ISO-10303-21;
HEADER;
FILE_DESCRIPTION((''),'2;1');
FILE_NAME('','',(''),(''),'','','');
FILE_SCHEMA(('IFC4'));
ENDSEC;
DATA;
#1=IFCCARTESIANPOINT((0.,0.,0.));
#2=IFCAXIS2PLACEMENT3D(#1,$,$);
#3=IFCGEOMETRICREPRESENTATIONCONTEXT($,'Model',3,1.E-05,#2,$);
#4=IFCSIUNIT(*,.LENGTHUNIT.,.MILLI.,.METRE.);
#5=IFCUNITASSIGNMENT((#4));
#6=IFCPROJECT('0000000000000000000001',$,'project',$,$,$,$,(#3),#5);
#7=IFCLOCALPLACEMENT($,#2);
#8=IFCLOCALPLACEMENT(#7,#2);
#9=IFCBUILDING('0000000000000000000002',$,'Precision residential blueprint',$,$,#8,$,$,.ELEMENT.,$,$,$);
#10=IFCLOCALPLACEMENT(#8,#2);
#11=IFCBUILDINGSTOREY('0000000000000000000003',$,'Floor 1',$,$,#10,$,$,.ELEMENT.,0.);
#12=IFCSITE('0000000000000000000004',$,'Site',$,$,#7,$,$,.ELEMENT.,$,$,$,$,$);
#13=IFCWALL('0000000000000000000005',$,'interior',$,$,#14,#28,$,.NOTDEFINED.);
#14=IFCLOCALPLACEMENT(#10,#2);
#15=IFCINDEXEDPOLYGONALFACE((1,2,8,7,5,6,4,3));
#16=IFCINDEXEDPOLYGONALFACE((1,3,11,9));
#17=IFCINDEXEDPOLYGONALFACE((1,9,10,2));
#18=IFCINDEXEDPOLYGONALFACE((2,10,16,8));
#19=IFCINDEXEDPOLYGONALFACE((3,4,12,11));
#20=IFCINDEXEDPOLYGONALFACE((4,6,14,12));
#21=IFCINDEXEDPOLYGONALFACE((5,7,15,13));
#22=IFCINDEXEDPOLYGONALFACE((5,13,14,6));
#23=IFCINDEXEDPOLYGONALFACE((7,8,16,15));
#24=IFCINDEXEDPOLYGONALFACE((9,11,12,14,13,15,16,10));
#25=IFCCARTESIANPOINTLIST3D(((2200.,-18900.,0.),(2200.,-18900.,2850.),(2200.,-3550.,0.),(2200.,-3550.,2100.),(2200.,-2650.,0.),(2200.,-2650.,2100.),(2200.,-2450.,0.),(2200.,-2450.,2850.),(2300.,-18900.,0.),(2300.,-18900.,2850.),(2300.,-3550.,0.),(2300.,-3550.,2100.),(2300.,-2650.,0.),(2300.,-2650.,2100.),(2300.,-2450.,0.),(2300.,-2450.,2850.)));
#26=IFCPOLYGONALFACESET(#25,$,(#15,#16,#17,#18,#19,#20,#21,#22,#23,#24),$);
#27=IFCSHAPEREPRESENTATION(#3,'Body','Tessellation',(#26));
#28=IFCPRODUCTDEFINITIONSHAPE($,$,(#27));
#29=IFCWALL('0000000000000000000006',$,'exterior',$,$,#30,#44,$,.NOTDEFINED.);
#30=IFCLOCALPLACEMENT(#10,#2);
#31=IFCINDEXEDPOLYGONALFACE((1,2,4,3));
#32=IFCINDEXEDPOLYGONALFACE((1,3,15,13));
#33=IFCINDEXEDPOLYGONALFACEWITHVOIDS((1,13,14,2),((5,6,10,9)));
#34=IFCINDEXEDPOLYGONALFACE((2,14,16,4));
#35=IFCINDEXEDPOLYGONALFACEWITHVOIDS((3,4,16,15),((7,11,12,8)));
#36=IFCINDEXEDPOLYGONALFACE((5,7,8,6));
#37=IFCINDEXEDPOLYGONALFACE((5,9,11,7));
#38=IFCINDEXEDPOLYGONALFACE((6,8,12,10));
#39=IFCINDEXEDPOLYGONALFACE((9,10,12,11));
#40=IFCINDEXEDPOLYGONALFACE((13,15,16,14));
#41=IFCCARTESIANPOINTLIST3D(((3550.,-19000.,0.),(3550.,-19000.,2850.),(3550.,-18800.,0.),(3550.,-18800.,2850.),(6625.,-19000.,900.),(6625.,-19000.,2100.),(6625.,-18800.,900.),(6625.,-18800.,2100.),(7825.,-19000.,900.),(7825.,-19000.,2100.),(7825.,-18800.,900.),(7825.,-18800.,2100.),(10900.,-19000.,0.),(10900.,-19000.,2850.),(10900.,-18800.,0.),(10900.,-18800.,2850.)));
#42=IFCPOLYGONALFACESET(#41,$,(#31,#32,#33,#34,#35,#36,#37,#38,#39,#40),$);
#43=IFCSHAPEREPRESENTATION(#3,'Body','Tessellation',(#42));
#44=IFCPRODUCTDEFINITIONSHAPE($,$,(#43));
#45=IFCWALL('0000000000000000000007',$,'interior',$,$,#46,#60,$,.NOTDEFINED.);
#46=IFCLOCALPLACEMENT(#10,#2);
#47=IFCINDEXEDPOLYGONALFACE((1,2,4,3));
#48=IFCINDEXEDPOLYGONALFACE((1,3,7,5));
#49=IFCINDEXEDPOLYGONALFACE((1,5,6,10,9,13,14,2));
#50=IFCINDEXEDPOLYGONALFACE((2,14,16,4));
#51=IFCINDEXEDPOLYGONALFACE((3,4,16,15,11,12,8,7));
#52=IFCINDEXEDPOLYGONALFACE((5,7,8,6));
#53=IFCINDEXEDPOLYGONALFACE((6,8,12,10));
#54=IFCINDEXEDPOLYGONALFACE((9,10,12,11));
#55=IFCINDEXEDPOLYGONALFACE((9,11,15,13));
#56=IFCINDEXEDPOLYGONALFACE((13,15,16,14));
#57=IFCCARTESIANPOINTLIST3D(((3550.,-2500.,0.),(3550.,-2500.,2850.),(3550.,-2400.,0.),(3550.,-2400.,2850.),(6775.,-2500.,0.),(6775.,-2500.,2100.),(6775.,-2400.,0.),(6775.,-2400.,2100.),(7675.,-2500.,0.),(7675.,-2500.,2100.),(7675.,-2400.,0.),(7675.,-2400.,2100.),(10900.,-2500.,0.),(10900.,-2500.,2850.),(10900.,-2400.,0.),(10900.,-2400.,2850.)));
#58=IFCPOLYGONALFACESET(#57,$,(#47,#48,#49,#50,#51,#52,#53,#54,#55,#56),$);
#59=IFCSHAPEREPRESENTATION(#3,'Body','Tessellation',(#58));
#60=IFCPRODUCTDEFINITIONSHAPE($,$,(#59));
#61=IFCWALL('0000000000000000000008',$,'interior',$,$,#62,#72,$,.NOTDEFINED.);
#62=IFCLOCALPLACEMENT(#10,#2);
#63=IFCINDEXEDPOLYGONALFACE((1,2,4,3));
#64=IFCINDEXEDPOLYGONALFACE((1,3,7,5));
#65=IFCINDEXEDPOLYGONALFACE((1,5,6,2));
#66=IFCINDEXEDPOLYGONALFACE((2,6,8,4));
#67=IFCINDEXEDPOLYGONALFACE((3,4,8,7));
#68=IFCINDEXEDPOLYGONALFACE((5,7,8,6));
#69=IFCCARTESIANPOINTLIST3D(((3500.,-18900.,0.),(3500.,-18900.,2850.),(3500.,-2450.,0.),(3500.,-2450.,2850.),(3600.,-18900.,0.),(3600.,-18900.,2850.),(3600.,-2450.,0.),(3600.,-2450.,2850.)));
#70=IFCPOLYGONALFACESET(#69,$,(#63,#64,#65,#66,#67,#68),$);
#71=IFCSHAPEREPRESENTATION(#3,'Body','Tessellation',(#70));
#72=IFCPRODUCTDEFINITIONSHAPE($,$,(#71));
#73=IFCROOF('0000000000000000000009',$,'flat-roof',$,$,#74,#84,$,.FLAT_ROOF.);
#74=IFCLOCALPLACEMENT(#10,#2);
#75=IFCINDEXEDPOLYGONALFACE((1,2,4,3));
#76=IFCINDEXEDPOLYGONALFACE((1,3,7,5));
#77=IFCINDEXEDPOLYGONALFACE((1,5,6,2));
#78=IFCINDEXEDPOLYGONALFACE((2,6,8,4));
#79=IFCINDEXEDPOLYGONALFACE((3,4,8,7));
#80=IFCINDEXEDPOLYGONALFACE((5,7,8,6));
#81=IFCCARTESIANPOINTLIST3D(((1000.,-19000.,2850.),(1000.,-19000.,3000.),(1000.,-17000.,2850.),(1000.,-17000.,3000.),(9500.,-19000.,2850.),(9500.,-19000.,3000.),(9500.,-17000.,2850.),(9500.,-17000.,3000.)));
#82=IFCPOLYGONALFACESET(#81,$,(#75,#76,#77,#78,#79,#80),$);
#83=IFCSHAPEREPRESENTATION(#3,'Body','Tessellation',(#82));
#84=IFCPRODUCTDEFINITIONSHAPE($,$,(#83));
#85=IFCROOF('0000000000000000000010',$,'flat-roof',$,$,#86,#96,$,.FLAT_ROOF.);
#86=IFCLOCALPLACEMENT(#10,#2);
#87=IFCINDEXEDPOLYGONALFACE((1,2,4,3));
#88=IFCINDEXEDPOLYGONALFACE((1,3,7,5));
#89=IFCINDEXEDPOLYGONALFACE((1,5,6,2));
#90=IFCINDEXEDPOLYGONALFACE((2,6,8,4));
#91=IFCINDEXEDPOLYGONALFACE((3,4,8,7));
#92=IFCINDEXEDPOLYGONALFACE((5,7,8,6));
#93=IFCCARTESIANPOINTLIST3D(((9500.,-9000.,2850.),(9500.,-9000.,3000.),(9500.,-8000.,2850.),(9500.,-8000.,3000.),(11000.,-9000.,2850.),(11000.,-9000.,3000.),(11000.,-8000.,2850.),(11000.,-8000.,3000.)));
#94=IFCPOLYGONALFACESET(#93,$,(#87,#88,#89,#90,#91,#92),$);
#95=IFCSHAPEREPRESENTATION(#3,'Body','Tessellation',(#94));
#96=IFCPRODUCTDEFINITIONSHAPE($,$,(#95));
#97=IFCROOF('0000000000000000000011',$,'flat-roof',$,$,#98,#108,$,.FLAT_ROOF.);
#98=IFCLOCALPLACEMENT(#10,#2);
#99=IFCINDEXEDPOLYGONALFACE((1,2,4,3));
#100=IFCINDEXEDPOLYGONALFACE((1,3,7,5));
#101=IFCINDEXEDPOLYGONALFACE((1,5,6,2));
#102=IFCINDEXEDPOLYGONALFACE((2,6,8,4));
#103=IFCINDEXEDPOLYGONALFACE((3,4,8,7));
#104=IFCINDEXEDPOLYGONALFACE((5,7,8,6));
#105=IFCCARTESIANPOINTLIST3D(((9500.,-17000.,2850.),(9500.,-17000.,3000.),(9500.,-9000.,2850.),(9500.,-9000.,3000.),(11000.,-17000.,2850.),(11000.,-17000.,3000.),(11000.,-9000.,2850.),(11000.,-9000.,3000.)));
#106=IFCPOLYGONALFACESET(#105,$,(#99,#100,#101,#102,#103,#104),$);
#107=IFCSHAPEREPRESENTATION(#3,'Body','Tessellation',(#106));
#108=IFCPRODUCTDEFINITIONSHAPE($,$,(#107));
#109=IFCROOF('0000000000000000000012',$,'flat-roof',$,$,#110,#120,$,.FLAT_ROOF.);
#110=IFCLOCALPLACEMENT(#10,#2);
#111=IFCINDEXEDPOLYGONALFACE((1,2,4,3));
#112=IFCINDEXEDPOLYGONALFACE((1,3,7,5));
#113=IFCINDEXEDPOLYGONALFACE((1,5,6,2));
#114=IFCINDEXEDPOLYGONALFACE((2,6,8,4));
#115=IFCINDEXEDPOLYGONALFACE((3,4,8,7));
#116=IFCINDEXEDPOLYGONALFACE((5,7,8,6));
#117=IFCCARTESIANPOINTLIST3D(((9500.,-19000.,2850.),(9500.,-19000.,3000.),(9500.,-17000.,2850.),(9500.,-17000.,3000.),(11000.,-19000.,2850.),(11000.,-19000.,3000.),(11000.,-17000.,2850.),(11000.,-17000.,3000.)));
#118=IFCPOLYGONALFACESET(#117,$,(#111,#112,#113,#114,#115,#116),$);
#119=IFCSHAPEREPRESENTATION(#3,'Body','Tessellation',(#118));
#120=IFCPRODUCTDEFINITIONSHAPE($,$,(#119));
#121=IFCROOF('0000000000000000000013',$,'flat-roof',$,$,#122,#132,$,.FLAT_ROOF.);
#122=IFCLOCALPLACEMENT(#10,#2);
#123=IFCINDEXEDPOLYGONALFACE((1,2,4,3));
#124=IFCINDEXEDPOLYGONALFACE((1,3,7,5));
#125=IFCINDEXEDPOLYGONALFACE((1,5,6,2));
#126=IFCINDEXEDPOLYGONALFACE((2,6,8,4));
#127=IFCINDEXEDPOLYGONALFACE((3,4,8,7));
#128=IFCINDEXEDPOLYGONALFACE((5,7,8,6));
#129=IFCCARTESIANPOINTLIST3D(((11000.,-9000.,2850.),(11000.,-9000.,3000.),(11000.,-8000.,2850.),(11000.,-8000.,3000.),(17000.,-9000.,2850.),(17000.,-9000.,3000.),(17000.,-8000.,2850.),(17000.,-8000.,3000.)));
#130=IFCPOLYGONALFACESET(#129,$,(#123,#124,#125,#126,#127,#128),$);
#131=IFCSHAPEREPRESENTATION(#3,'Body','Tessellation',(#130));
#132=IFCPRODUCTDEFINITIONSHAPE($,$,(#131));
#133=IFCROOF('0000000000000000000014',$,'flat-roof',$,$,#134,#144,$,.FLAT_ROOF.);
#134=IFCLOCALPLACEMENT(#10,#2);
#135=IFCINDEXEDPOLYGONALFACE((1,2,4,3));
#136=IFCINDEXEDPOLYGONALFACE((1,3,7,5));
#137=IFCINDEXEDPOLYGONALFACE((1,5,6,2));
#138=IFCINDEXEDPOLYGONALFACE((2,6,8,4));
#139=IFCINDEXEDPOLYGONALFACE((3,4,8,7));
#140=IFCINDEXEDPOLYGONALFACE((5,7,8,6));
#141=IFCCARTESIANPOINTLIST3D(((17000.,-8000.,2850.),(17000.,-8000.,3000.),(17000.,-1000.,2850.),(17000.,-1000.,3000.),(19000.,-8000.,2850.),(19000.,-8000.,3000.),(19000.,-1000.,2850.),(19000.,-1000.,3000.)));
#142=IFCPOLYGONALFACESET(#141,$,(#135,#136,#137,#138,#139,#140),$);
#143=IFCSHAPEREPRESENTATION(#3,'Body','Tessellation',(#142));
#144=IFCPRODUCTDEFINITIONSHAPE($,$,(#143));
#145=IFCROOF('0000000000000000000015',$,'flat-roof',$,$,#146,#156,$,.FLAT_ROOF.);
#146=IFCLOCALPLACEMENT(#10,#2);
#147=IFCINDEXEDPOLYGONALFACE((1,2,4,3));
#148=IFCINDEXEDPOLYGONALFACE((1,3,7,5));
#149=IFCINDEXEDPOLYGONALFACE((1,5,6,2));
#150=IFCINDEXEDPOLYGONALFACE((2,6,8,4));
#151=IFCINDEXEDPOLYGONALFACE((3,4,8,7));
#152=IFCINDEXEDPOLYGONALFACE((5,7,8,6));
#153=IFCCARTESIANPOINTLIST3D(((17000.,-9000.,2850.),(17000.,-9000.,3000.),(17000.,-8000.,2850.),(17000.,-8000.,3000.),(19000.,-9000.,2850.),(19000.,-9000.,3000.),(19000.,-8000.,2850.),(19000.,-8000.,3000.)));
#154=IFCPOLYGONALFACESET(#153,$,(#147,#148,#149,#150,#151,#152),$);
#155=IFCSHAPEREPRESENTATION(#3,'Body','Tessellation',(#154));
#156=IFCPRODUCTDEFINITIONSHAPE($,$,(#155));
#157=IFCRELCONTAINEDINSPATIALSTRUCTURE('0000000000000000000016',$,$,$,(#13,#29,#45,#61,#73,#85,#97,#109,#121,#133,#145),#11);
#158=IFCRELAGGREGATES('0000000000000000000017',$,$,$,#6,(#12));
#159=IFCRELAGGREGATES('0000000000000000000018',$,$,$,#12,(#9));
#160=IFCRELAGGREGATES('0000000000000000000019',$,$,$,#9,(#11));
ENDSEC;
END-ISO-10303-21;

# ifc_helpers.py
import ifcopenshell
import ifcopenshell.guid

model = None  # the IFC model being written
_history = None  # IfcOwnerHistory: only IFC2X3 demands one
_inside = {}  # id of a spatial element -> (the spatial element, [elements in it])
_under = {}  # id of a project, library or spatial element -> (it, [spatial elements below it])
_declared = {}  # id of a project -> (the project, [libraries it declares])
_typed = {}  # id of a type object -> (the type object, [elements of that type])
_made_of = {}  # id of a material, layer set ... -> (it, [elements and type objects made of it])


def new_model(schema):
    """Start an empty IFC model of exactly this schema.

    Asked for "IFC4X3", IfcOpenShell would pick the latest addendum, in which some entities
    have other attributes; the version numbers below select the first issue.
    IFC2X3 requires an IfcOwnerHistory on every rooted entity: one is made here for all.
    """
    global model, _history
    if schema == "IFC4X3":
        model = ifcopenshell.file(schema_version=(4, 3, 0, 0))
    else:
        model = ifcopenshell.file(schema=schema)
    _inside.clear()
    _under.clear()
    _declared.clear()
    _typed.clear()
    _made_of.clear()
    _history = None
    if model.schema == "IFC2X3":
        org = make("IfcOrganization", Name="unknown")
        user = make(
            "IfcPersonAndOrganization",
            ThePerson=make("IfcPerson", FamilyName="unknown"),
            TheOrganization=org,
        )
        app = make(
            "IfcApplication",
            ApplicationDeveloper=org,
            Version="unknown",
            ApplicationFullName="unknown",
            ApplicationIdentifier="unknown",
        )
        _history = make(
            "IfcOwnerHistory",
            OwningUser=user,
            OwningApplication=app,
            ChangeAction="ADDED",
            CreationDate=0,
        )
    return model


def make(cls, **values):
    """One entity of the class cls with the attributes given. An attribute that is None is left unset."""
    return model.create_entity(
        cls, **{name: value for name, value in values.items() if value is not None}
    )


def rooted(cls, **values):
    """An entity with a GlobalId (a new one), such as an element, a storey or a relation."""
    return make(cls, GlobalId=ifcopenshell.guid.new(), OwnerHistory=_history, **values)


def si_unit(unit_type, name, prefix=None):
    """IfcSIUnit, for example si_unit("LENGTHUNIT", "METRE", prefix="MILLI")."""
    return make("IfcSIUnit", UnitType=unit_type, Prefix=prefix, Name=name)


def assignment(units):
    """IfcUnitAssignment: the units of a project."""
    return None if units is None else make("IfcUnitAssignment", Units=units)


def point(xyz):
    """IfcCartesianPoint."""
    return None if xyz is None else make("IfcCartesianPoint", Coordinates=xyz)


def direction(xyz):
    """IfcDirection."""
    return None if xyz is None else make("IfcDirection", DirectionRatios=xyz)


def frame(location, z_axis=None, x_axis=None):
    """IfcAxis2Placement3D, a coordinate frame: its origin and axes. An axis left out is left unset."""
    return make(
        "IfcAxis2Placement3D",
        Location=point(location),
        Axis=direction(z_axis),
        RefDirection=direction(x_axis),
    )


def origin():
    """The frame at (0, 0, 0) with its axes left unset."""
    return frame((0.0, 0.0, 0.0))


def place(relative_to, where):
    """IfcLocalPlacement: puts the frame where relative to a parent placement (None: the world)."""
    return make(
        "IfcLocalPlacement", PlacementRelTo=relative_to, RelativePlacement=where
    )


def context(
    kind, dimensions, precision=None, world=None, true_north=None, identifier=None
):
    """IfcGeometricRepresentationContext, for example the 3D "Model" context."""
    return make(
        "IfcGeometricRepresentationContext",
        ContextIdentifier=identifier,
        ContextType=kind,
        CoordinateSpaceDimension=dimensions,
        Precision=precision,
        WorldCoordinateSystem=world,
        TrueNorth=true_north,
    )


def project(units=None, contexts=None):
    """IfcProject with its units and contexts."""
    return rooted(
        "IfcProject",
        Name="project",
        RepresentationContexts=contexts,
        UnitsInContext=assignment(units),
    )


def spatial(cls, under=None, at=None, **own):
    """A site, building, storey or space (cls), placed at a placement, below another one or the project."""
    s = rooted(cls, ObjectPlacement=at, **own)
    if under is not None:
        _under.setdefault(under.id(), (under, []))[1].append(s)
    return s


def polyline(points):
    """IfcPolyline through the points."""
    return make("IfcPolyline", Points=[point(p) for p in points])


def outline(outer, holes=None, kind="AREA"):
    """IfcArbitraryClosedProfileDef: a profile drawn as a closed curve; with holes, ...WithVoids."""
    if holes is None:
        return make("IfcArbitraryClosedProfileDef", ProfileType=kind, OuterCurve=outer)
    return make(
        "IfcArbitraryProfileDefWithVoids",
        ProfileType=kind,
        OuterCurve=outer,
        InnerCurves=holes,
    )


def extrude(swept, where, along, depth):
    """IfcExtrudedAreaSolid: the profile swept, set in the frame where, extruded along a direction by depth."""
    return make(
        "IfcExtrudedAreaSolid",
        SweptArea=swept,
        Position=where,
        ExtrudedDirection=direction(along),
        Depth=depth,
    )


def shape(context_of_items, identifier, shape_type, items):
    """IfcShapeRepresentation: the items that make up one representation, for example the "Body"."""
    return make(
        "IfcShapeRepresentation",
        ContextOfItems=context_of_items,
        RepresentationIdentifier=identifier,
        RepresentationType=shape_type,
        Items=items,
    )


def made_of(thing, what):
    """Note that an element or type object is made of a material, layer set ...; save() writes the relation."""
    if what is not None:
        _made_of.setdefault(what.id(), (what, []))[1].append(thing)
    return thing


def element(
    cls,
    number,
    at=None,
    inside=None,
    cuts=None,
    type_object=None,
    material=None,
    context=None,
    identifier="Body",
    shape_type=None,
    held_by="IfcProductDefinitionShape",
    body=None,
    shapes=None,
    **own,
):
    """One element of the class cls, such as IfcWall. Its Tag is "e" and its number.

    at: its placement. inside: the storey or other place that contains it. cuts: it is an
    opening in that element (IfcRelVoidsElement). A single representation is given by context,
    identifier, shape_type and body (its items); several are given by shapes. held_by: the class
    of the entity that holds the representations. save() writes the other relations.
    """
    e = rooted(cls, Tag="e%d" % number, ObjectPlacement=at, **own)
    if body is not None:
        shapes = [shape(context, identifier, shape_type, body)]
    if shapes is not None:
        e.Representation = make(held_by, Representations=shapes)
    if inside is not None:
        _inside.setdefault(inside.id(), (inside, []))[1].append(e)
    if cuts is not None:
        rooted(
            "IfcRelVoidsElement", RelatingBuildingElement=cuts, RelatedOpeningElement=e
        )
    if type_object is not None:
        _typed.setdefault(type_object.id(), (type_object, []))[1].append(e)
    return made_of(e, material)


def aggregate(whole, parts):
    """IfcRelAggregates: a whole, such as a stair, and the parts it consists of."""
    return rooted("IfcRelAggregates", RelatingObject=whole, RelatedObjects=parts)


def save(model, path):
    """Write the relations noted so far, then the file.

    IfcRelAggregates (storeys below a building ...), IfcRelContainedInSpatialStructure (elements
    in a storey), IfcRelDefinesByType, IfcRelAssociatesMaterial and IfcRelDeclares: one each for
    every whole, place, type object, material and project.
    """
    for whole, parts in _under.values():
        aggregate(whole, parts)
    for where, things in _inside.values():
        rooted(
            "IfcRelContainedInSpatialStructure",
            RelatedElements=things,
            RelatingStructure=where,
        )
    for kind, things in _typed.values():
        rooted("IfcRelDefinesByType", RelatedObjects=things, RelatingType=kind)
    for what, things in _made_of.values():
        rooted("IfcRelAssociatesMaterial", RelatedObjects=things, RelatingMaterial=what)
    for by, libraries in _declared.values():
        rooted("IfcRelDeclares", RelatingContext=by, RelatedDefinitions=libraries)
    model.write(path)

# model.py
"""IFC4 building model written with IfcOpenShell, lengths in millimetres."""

from ifc_helpers import new_model, si_unit, frame, origin, place, context, project, spatial, polyline, outline, extrude, element, save


model = new_model("IFC4")

# Units and contexts
model_context = context("Model", 3, precision=1e-05, world=origin())
ifc_project = project(units=[si_unit("LENGTHUNIT", "METRE", prefix="MILLI")], contexts=[model_context])

# Site, building, storey
site_placement = place(None, origin())
site = spatial("IfcSite", under=ifc_project, at=site_placement, Name="Site", CompositionType="ELEMENT")
building_placement = place(site_placement, origin())
building = spatial("IfcBuilding", under=site, at=building_placement, Name="Precision residential blueprint", CompositionType="ELEMENT")
storey_placement = place(building_placement, origin())
storey = spatial("IfcBuildingStorey", under=building, at=storey_placement, Name="Floor 1", CompositionType="ELEMENT", Elevation=0.0)

# Walls, openings
wall_1_placement = place(storey_placement, origin())
wall_1 = element("IfcWall", 1, at=wall_1_placement, inside=storey, Name="interior", PredefinedType="NOTDEFINED", context=model_context, shape_type="SweptSolid", body=[
    extrude(outline(polyline([(2300.0, -2450.0), (2300.0, -18900.0), (2200.0, -18900.0), (2200.0, -2450.0), (2300.0, -2450.0)])), origin(), (0.0, 0.0, 1.0), 2850.0),
])
opening_1_placement = place(storey_placement, origin())
element("IfcOpeningElement", 2, at=opening_1_placement, cuts=wall_1, PredefinedType="OPENING", context=model_context, shape_type="SweptSolid", body=[
    extrude(outline(polyline([(2300.0, -2650.0), (2300.0, -3550.0), (2200.0, -3550.0), (2200.0, -2650.0), (2300.0, -2650.0)])), origin(), (0.0, 0.0, 1.0), 2100.0),
])
wall_2_placement = place(storey_placement, origin())
wall_2 = element("IfcWall", 3, at=wall_2_placement, inside=storey, Name="exterior", PredefinedType="NOTDEFINED", context=model_context, shape_type="SweptSolid", body=[
    extrude(outline(polyline([(3550.0, -18800.0), (10900.0, -18800.0), (10900.0, -19000.0), (3550.0, -19000.0), (3550.0, -18800.0)])), origin(), (0.0, 0.0, 1.0), 2850.0),
])
opening_2_placement = place(storey_placement, origin())
element("IfcOpeningElement", 4, at=opening_2_placement, cuts=wall_2, PredefinedType="OPENING", context=model_context, shape_type="SweptSolid", body=[
    extrude(outline(polyline([(6625.0, -18800.0), (7825.0, -18800.0), (7825.0, -19000.0), (6625.0, -19000.0), (6625.0, -18800.0)])), frame((0.0, 0.0, 900.0)), (0.0, 0.0, 1.0), 1200.0),
])
wall_3_placement = place(storey_placement, origin())
wall_3 = element("IfcWall", 5, at=wall_3_placement, inside=storey, Name="interior", PredefinedType="NOTDEFINED", context=model_context, shape_type="SweptSolid", body=[
    extrude(outline(polyline([(3550.0, -2400.0), (10900.0, -2400.0), (10900.0, -2500.0), (3550.0, -2500.0), (3550.0, -2400.0)])), origin(), (0.0, 0.0, 1.0), 2850.0),
])
opening_3_placement = place(storey_placement, origin())
element("IfcOpeningElement", 6, at=opening_3_placement, cuts=wall_3, PredefinedType="OPENING", context=model_context, shape_type="SweptSolid", body=[
    extrude(outline(polyline([(6775.0, -2400.0), (7675.0, -2400.0), (7675.0, -2500.0), (6775.0, -2500.0), (6775.0, -2400.0)])), origin(), (0.0, 0.0, 1.0), 2100.0),
])

# Wall
wall_4_placement = place(storey_placement, origin())
element("IfcWall", 7, at=wall_4_placement, inside=storey, Name="interior", PredefinedType="NOTDEFINED", context=model_context, shape_type="SweptSolid", body=[
    extrude(outline(polyline([(3600.0, -2450.0), (3600.0, -18900.0), (3500.0, -18900.0), (3500.0, -2450.0), (3600.0, -2450.0)])), origin(), (0.0, 0.0, 1.0), 2850.0),
])

# Roofs
roof_1_placement = place(storey_placement, origin())
element("IfcRoof", 8, at=roof_1_placement, inside=storey, Name="flat-roof", PredefinedType="FLAT_ROOF", context=model_context, shape_type="SweptSolid", body=[
    extrude(outline(polyline([(1000.0, -19000.0), (9500.0, -19000.0), (9500.0, -17000.0), (1000.0, -17000.0), (1000.0, -19000.0)])), frame((0.0, 0.0, 2850.0)), (0.0, 0.0, 1.0), 150.0),
])
roof_2_placement = place(storey_placement, origin())
element("IfcRoof", 9, at=roof_2_placement, inside=storey, Name="flat-roof", PredefinedType="FLAT_ROOF", context=model_context, shape_type="SweptSolid", body=[
    extrude(outline(polyline([(9500.0, -9000.0), (11000.0, -9000.0), (11000.0, -8000.0), (9500.0, -8000.0), (9500.0, -9000.0)])), frame((0.0, 0.0, 2850.0)), (0.0, 0.0, 1.0), 150.0),
])
roof_3_placement = place(storey_placement, origin())
element("IfcRoof", 10, at=roof_3_placement, inside=storey, Name="flat-roof", PredefinedType="FLAT_ROOF", context=model_context, shape_type="SweptSolid", body=[
    extrude(outline(polyline([(9500.0, -17000.0), (11000.0, -17000.0), (11000.0, -9000.0), (9500.0, -9000.0), (9500.0, -17000.0)])), frame((0.0, 0.0, 2850.0)), (0.0, 0.0, 1.0), 150.0),
])
roof_4_placement = place(storey_placement, origin())
element("IfcRoof", 11, at=roof_4_placement, inside=storey, Name="flat-roof", PredefinedType="FLAT_ROOF", context=model_context, shape_type="SweptSolid", body=[
    extrude(outline(polyline([(9500.0, -19000.0), (11000.0, -19000.0), (11000.0, -17000.0), (9500.0, -17000.0), (9500.0, -19000.0)])), frame((0.0, 0.0, 2850.0)), (0.0, 0.0, 1.0), 150.0),
])
roof_5_placement = place(storey_placement, origin())
element("IfcRoof", 12, at=roof_5_placement, inside=storey, Name="flat-roof", PredefinedType="FLAT_ROOF", context=model_context, shape_type="SweptSolid", body=[
    extrude(outline(polyline([(11000.0, -9000.0), (17000.0, -9000.0), (17000.0, -8000.0), (11000.0, -8000.0), (11000.0, -9000.0)])), frame((0.0, 0.0, 2850.0)), (0.0, 0.0, 1.0), 150.0),
])
roof_6_placement = place(storey_placement, origin())
element("IfcRoof", 13, at=roof_6_placement, inside=storey, Name="flat-roof", PredefinedType="FLAT_ROOF", context=model_context, shape_type="SweptSolid", body=[
    extrude(outline(polyline([(17000.0, -8000.0), (19000.0, -8000.0), (19000.0, -1000.0), (17000.0, -1000.0), (17000.0, -8000.0)])), frame((0.0, 0.0, 2850.0)), (0.0, 0.0, 1.0), 150.0),
])
roof_7_placement = place(storey_placement, origin())
element("IfcRoof", 14, at=roof_7_placement, inside=storey, Name="flat-roof", PredefinedType="FLAT_ROOF", context=model_context, shape_type="SweptSolid", body=[
    extrude(outline(polyline([(17000.0, -9000.0), (19000.0, -9000.0), (19000.0, -8000.0), (17000.0, -8000.0), (17000.0, -9000.0)])), frame((0.0, 0.0, 2850.0)), (0.0, 0.0, 1.0), 150.0),
])

save(model, "model.ifc")
